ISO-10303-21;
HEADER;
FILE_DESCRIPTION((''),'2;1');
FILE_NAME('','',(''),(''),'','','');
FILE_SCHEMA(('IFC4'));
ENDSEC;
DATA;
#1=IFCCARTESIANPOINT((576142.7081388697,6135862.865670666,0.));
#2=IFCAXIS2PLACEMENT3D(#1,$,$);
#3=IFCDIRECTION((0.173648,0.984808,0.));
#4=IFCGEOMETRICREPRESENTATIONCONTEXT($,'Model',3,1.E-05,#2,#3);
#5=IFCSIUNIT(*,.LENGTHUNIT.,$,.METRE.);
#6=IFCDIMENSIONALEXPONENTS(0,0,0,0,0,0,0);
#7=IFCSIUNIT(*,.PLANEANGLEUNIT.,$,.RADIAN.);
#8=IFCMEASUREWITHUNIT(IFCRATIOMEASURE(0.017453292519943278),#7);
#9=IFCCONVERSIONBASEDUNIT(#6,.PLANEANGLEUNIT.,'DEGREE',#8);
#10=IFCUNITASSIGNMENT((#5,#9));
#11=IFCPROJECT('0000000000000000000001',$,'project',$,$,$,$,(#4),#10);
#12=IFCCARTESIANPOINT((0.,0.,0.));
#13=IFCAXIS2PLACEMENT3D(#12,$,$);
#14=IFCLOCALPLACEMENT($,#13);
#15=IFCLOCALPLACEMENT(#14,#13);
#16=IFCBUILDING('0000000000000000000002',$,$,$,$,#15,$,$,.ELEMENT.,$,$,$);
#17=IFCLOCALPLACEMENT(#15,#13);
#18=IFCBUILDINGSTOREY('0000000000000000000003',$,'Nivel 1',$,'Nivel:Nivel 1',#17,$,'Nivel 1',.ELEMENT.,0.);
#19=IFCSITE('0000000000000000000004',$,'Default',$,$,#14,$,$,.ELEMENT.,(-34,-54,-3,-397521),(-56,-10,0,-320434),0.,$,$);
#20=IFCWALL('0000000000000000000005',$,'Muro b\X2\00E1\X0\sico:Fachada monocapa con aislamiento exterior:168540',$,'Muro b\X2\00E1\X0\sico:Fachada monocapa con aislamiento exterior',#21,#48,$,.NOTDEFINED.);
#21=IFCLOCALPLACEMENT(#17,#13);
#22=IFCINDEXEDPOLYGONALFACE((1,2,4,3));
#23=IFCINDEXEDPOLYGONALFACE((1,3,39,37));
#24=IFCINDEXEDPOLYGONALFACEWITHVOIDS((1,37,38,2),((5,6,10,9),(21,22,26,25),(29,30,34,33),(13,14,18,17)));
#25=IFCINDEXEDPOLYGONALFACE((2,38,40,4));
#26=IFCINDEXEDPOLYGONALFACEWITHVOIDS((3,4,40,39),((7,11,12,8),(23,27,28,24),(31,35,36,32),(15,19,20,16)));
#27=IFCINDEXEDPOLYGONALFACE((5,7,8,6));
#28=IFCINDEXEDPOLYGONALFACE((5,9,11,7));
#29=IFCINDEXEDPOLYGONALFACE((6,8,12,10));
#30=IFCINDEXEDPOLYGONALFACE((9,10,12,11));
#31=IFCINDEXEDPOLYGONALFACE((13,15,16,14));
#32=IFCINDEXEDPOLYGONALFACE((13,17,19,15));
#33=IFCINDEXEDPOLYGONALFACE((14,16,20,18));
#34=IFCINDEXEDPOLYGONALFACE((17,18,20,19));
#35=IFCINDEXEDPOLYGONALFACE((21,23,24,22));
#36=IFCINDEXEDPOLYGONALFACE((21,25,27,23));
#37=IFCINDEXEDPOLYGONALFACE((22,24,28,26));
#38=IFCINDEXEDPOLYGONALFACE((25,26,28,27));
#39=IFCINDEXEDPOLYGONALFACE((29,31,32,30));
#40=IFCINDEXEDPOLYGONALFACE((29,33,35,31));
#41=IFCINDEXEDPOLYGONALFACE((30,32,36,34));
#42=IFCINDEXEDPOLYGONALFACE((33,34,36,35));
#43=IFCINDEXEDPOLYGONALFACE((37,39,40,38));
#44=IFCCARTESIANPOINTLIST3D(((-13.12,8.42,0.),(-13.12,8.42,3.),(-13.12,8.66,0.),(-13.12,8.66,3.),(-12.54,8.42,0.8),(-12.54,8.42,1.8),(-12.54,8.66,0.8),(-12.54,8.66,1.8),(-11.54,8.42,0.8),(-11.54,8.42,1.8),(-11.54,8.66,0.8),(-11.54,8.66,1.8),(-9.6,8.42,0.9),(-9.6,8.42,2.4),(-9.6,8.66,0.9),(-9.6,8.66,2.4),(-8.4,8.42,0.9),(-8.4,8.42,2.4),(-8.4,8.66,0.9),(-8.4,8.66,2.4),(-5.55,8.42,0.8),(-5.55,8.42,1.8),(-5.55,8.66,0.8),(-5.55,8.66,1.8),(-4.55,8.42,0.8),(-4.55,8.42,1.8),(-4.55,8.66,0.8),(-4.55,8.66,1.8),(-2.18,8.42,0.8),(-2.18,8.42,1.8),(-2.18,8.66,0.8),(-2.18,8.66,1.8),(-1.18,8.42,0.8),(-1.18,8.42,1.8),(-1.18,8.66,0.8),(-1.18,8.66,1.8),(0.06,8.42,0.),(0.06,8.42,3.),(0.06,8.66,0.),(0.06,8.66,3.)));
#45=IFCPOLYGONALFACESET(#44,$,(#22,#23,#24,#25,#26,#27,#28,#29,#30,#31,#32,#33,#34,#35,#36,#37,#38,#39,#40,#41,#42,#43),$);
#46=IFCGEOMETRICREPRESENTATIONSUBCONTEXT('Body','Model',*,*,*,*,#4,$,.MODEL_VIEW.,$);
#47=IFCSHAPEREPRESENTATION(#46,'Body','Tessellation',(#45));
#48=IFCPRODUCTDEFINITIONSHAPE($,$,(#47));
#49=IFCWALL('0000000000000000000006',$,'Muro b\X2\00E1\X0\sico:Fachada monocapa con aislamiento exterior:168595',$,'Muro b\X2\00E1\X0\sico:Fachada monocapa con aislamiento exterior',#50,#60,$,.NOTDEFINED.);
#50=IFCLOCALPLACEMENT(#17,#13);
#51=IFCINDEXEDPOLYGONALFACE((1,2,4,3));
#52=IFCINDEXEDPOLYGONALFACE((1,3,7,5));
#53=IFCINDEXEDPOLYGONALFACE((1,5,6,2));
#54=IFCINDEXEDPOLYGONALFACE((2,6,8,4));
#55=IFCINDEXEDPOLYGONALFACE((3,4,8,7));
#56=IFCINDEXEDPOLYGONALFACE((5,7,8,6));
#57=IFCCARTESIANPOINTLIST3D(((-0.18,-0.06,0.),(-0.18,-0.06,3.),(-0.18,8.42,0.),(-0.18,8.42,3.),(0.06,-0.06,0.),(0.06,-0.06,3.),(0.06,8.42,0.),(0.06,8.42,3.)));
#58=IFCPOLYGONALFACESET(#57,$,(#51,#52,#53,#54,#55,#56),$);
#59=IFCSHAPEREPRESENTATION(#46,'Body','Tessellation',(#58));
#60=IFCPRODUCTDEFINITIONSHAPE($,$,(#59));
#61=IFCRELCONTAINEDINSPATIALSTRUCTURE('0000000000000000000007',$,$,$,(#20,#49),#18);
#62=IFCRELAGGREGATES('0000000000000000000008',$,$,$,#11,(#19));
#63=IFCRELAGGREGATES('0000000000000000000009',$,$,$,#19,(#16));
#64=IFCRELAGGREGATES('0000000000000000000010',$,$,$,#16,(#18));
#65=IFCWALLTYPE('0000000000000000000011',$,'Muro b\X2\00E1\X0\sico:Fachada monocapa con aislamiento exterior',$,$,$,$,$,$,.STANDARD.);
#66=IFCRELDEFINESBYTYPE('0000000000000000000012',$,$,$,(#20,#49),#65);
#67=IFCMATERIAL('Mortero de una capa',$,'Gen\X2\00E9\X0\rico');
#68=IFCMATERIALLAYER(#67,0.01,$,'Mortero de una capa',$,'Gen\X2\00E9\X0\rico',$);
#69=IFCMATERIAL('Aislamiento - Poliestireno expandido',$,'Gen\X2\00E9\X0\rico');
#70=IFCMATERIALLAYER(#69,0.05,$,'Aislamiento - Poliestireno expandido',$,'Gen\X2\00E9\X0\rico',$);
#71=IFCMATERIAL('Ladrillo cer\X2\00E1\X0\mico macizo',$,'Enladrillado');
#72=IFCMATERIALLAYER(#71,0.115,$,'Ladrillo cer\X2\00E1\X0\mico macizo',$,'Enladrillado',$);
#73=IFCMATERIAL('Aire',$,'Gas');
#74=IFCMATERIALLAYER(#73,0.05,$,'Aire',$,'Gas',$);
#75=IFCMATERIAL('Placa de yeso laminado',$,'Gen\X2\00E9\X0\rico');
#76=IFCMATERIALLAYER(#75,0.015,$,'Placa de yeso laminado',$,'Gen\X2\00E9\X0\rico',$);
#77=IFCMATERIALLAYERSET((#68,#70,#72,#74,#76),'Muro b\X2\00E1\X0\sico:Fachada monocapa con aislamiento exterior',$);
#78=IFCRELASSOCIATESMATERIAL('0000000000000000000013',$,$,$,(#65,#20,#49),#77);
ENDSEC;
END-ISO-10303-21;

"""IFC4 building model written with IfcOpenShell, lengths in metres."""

from ifc_helpers import new_model, entity, si_unit, converted_unit, direction, frame, frame_2d, origin, place, context, subcontext, project, spatial, rectangle, extrude, material, layer, layer_set, layer_usage, type_object, element, save


model = new_model("IFC4")

# Units and contexts
model_context = context("Model", 3, precision=1e-05, world=frame((576142.7081388697, 6135862.865670666, 0.0)), true_north=direction((0.173648, 0.984808, 0.0)))
body_context = subcontext(model_context, "Body", "Model", "MODEL_VIEW")
ifc_project = project(units=[si_unit("LENGTHUNIT", "METRE"), converted_unit("PLANEANGLEUNIT", "DEGREE", entity("IfcRatioMeasure", 0.017453292519943278), si_unit("PLANEANGLEUNIT", "RADIAN"), dimensions=[0, 0, 0, 0, 0, 0, 0])], contexts=[model_context])

# Site, building, storey
site_placement = place(None, origin())
site = spatial("IfcSite", under=ifc_project, at=site_placement, Name="Default", CompositionType="ELEMENT", RefLatitude=(-34, -54, -3, -397521), RefLongitude=(-56, -10, 0, -320434), RefElevation=0.0)
building_placement = place(site_placement, origin())
building = spatial("IfcBuilding", under=site, at=building_placement, CompositionType="ELEMENT")
storey_placement = place(building_placement, origin())
storey = spatial("IfcBuildingStorey", under=building, at=storey_placement, Name="Nivel 1", ObjectType="Nivel:Nivel 1", LongName="Nivel 1", CompositionType="ELEMENT", Elevation=0.0)

# Shared definitions
ifc_material_1 = material(Name="Mortero de una capa", Category="Genérico")
ifc_layer_1 = layer(ifc_material_1, 0.01, Name="Mortero de una capa", Category="Genérico")
ifc_material_2 = material(Name="Aislamiento - Poliestireno expandido", Category="Genérico")
ifc_layer_2 = layer(ifc_material_2, 0.05, Name="Aislamiento - Poliestireno expandido", Category="Genérico")
ifc_material_3 = material(Name="Ladrillo cerámico macizo", Category="Enladrillado")
ifc_layer_3 = layer(ifc_material_3, 0.115, Name="Ladrillo cerámico macizo", Category="Enladrillado")
ifc_material_4 = material(Name="Aire", Category="Gas")
ifc_layer_4 = layer(ifc_material_4, 0.05, Name="Aire", Category="Gas")
ifc_material_5 = material(Name="Placa de yeso laminado", Category="Genérico")
ifc_layer_5 = layer(ifc_material_5, 0.015, Name="Placa de yeso laminado", Category="Genérico")
ifc_layer_set_1 = layer_set([ifc_layer_1, ifc_layer_2, ifc_layer_3, ifc_layer_4, ifc_layer_5], Name="Muro básico:Fachada monocapa con aislamiento exterior")
ifc_layer_usage_1 = layer_usage(ifc_layer_set_1, "AXIS2", "NEGATIVE", 0.12)
wall_type_1 = type_object("IfcWallType", Name="Muro básico:Fachada monocapa con aislamiento exterior", PredefinedType="STANDARD", material=ifc_layer_set_1)

# Wall, openings
wall_1_placement = place(storey_placement, frame((-13.12, 8.54, 0.0)))
wall_1 = element("IfcWall", 1, at=wall_1_placement, inside=storey, type_object=wall_type_1, material=ifc_layer_usage_1, Name="Muro básico:Fachada monocapa con aislamiento exterior:168540", ObjectType="Muro básico:Fachada monocapa con aislamiento exterior", PredefinedType="NOTDEFINED", context=body_context, shape_type="SweptSolid", body=[
    extrude(rectangle(XDim=13.18, YDim=0.24, at=frame_2d((6.59, 0.0), x_axis=(-1.0, 0.0))), origin(), (0.0, 0.0, 1.0), 3.0),
])
opening_1_placement = place(wall_1_placement, frame((10.94, -0.12, 0.8)))
element("IfcOpeningElement", 2, at=opening_1_placement, cuts=wall_1, PredefinedType="OPENING", context=body_context, shape_type="SweptSolid", body=[
    extrude(rectangle(XDim=1.0, YDim=1.0, at=frame_2d((0.5, 0.5), x_axis=(1.0, 0.0))), frame((0.0, 0.0, 0.0), z_axis=(0.0, 1.0, 0.0), x_axis=(0.0, 0.0, 1.0)), (0.0, 0.0, 1.0), 0.24),
])
opening_2_placement = place(wall_1_placement, frame((7.57, -0.12, 0.8)))
element("IfcOpeningElement", 3, at=opening_2_placement, cuts=wall_1, PredefinedType="OPENING", context=body_context, shape_type="SweptSolid", body=[
    extrude(rectangle(XDim=1.0, YDim=1.0, at=frame_2d((0.5, 0.5), x_axis=(1.0, 0.0))), frame((0.0, 0.0, 0.0), z_axis=(0.0, 1.0, 0.0), x_axis=(0.0, 0.0, 1.0)), (0.0, 0.0, 1.0), 0.24),
])
opening_3_placement = place(wall_1_placement, frame((0.58, -0.12, 0.8)))
element("IfcOpeningElement", 4, at=opening_3_placement, cuts=wall_1, PredefinedType="OPENING", context=body_context, shape_type="SweptSolid", body=[
    extrude(rectangle(XDim=1.0, YDim=1.0, at=frame_2d((0.5, 0.5), x_axis=(1.0, 0.0))), frame((0.0, 0.0, 0.0), z_axis=(0.0, 1.0, 0.0), x_axis=(0.0, 0.0, 1.0)), (0.0, 0.0, 1.0), 0.24),
])
opening_4_placement = place(wall_1_placement, frame((3.52, -0.12, 0.9)))
element("IfcOpeningElement", 5, at=opening_4_placement, cuts=wall_1, PredefinedType="OPENING", context=body_context, shape_type="SweptSolid", body=[
    extrude(rectangle(XDim=1.5, YDim=1.2, at=frame_2d((0.75, 0.6), x_axis=(1.0, 0.0))), frame((0.0, 0.0, 0.0), z_axis=(0.0, 1.0, 0.0), x_axis=(0.0, 0.0, 1.0)), (0.0, 0.0, 1.0), 0.24),
])

# Wall
wall_2_placement = place(storey_placement, frame((-0.06, 8.42, 0.0), z_axis=(0.0, 0.0, 1.0), x_axis=(0.0, -1.0, 0.0)))
element("IfcWall", 6, at=wall_2_placement, inside=storey, type_object=wall_type_1, material=ifc_layer_usage_1, Name="Muro básico:Fachada monocapa con aislamiento exterior:168595", ObjectType="Muro básico:Fachada monocapa con aislamiento exterior", PredefinedType="NOTDEFINED", context=body_context, shape_type="SweptSolid", body=[
    extrude(rectangle(XDim=8.48, YDim=0.24, at=frame_2d((4.24, 0.0), x_axis=(-1.0, 0.0))), origin(), (0.0, 0.0, 1.0), 3.0),
])

save(model, "model.ifc")
